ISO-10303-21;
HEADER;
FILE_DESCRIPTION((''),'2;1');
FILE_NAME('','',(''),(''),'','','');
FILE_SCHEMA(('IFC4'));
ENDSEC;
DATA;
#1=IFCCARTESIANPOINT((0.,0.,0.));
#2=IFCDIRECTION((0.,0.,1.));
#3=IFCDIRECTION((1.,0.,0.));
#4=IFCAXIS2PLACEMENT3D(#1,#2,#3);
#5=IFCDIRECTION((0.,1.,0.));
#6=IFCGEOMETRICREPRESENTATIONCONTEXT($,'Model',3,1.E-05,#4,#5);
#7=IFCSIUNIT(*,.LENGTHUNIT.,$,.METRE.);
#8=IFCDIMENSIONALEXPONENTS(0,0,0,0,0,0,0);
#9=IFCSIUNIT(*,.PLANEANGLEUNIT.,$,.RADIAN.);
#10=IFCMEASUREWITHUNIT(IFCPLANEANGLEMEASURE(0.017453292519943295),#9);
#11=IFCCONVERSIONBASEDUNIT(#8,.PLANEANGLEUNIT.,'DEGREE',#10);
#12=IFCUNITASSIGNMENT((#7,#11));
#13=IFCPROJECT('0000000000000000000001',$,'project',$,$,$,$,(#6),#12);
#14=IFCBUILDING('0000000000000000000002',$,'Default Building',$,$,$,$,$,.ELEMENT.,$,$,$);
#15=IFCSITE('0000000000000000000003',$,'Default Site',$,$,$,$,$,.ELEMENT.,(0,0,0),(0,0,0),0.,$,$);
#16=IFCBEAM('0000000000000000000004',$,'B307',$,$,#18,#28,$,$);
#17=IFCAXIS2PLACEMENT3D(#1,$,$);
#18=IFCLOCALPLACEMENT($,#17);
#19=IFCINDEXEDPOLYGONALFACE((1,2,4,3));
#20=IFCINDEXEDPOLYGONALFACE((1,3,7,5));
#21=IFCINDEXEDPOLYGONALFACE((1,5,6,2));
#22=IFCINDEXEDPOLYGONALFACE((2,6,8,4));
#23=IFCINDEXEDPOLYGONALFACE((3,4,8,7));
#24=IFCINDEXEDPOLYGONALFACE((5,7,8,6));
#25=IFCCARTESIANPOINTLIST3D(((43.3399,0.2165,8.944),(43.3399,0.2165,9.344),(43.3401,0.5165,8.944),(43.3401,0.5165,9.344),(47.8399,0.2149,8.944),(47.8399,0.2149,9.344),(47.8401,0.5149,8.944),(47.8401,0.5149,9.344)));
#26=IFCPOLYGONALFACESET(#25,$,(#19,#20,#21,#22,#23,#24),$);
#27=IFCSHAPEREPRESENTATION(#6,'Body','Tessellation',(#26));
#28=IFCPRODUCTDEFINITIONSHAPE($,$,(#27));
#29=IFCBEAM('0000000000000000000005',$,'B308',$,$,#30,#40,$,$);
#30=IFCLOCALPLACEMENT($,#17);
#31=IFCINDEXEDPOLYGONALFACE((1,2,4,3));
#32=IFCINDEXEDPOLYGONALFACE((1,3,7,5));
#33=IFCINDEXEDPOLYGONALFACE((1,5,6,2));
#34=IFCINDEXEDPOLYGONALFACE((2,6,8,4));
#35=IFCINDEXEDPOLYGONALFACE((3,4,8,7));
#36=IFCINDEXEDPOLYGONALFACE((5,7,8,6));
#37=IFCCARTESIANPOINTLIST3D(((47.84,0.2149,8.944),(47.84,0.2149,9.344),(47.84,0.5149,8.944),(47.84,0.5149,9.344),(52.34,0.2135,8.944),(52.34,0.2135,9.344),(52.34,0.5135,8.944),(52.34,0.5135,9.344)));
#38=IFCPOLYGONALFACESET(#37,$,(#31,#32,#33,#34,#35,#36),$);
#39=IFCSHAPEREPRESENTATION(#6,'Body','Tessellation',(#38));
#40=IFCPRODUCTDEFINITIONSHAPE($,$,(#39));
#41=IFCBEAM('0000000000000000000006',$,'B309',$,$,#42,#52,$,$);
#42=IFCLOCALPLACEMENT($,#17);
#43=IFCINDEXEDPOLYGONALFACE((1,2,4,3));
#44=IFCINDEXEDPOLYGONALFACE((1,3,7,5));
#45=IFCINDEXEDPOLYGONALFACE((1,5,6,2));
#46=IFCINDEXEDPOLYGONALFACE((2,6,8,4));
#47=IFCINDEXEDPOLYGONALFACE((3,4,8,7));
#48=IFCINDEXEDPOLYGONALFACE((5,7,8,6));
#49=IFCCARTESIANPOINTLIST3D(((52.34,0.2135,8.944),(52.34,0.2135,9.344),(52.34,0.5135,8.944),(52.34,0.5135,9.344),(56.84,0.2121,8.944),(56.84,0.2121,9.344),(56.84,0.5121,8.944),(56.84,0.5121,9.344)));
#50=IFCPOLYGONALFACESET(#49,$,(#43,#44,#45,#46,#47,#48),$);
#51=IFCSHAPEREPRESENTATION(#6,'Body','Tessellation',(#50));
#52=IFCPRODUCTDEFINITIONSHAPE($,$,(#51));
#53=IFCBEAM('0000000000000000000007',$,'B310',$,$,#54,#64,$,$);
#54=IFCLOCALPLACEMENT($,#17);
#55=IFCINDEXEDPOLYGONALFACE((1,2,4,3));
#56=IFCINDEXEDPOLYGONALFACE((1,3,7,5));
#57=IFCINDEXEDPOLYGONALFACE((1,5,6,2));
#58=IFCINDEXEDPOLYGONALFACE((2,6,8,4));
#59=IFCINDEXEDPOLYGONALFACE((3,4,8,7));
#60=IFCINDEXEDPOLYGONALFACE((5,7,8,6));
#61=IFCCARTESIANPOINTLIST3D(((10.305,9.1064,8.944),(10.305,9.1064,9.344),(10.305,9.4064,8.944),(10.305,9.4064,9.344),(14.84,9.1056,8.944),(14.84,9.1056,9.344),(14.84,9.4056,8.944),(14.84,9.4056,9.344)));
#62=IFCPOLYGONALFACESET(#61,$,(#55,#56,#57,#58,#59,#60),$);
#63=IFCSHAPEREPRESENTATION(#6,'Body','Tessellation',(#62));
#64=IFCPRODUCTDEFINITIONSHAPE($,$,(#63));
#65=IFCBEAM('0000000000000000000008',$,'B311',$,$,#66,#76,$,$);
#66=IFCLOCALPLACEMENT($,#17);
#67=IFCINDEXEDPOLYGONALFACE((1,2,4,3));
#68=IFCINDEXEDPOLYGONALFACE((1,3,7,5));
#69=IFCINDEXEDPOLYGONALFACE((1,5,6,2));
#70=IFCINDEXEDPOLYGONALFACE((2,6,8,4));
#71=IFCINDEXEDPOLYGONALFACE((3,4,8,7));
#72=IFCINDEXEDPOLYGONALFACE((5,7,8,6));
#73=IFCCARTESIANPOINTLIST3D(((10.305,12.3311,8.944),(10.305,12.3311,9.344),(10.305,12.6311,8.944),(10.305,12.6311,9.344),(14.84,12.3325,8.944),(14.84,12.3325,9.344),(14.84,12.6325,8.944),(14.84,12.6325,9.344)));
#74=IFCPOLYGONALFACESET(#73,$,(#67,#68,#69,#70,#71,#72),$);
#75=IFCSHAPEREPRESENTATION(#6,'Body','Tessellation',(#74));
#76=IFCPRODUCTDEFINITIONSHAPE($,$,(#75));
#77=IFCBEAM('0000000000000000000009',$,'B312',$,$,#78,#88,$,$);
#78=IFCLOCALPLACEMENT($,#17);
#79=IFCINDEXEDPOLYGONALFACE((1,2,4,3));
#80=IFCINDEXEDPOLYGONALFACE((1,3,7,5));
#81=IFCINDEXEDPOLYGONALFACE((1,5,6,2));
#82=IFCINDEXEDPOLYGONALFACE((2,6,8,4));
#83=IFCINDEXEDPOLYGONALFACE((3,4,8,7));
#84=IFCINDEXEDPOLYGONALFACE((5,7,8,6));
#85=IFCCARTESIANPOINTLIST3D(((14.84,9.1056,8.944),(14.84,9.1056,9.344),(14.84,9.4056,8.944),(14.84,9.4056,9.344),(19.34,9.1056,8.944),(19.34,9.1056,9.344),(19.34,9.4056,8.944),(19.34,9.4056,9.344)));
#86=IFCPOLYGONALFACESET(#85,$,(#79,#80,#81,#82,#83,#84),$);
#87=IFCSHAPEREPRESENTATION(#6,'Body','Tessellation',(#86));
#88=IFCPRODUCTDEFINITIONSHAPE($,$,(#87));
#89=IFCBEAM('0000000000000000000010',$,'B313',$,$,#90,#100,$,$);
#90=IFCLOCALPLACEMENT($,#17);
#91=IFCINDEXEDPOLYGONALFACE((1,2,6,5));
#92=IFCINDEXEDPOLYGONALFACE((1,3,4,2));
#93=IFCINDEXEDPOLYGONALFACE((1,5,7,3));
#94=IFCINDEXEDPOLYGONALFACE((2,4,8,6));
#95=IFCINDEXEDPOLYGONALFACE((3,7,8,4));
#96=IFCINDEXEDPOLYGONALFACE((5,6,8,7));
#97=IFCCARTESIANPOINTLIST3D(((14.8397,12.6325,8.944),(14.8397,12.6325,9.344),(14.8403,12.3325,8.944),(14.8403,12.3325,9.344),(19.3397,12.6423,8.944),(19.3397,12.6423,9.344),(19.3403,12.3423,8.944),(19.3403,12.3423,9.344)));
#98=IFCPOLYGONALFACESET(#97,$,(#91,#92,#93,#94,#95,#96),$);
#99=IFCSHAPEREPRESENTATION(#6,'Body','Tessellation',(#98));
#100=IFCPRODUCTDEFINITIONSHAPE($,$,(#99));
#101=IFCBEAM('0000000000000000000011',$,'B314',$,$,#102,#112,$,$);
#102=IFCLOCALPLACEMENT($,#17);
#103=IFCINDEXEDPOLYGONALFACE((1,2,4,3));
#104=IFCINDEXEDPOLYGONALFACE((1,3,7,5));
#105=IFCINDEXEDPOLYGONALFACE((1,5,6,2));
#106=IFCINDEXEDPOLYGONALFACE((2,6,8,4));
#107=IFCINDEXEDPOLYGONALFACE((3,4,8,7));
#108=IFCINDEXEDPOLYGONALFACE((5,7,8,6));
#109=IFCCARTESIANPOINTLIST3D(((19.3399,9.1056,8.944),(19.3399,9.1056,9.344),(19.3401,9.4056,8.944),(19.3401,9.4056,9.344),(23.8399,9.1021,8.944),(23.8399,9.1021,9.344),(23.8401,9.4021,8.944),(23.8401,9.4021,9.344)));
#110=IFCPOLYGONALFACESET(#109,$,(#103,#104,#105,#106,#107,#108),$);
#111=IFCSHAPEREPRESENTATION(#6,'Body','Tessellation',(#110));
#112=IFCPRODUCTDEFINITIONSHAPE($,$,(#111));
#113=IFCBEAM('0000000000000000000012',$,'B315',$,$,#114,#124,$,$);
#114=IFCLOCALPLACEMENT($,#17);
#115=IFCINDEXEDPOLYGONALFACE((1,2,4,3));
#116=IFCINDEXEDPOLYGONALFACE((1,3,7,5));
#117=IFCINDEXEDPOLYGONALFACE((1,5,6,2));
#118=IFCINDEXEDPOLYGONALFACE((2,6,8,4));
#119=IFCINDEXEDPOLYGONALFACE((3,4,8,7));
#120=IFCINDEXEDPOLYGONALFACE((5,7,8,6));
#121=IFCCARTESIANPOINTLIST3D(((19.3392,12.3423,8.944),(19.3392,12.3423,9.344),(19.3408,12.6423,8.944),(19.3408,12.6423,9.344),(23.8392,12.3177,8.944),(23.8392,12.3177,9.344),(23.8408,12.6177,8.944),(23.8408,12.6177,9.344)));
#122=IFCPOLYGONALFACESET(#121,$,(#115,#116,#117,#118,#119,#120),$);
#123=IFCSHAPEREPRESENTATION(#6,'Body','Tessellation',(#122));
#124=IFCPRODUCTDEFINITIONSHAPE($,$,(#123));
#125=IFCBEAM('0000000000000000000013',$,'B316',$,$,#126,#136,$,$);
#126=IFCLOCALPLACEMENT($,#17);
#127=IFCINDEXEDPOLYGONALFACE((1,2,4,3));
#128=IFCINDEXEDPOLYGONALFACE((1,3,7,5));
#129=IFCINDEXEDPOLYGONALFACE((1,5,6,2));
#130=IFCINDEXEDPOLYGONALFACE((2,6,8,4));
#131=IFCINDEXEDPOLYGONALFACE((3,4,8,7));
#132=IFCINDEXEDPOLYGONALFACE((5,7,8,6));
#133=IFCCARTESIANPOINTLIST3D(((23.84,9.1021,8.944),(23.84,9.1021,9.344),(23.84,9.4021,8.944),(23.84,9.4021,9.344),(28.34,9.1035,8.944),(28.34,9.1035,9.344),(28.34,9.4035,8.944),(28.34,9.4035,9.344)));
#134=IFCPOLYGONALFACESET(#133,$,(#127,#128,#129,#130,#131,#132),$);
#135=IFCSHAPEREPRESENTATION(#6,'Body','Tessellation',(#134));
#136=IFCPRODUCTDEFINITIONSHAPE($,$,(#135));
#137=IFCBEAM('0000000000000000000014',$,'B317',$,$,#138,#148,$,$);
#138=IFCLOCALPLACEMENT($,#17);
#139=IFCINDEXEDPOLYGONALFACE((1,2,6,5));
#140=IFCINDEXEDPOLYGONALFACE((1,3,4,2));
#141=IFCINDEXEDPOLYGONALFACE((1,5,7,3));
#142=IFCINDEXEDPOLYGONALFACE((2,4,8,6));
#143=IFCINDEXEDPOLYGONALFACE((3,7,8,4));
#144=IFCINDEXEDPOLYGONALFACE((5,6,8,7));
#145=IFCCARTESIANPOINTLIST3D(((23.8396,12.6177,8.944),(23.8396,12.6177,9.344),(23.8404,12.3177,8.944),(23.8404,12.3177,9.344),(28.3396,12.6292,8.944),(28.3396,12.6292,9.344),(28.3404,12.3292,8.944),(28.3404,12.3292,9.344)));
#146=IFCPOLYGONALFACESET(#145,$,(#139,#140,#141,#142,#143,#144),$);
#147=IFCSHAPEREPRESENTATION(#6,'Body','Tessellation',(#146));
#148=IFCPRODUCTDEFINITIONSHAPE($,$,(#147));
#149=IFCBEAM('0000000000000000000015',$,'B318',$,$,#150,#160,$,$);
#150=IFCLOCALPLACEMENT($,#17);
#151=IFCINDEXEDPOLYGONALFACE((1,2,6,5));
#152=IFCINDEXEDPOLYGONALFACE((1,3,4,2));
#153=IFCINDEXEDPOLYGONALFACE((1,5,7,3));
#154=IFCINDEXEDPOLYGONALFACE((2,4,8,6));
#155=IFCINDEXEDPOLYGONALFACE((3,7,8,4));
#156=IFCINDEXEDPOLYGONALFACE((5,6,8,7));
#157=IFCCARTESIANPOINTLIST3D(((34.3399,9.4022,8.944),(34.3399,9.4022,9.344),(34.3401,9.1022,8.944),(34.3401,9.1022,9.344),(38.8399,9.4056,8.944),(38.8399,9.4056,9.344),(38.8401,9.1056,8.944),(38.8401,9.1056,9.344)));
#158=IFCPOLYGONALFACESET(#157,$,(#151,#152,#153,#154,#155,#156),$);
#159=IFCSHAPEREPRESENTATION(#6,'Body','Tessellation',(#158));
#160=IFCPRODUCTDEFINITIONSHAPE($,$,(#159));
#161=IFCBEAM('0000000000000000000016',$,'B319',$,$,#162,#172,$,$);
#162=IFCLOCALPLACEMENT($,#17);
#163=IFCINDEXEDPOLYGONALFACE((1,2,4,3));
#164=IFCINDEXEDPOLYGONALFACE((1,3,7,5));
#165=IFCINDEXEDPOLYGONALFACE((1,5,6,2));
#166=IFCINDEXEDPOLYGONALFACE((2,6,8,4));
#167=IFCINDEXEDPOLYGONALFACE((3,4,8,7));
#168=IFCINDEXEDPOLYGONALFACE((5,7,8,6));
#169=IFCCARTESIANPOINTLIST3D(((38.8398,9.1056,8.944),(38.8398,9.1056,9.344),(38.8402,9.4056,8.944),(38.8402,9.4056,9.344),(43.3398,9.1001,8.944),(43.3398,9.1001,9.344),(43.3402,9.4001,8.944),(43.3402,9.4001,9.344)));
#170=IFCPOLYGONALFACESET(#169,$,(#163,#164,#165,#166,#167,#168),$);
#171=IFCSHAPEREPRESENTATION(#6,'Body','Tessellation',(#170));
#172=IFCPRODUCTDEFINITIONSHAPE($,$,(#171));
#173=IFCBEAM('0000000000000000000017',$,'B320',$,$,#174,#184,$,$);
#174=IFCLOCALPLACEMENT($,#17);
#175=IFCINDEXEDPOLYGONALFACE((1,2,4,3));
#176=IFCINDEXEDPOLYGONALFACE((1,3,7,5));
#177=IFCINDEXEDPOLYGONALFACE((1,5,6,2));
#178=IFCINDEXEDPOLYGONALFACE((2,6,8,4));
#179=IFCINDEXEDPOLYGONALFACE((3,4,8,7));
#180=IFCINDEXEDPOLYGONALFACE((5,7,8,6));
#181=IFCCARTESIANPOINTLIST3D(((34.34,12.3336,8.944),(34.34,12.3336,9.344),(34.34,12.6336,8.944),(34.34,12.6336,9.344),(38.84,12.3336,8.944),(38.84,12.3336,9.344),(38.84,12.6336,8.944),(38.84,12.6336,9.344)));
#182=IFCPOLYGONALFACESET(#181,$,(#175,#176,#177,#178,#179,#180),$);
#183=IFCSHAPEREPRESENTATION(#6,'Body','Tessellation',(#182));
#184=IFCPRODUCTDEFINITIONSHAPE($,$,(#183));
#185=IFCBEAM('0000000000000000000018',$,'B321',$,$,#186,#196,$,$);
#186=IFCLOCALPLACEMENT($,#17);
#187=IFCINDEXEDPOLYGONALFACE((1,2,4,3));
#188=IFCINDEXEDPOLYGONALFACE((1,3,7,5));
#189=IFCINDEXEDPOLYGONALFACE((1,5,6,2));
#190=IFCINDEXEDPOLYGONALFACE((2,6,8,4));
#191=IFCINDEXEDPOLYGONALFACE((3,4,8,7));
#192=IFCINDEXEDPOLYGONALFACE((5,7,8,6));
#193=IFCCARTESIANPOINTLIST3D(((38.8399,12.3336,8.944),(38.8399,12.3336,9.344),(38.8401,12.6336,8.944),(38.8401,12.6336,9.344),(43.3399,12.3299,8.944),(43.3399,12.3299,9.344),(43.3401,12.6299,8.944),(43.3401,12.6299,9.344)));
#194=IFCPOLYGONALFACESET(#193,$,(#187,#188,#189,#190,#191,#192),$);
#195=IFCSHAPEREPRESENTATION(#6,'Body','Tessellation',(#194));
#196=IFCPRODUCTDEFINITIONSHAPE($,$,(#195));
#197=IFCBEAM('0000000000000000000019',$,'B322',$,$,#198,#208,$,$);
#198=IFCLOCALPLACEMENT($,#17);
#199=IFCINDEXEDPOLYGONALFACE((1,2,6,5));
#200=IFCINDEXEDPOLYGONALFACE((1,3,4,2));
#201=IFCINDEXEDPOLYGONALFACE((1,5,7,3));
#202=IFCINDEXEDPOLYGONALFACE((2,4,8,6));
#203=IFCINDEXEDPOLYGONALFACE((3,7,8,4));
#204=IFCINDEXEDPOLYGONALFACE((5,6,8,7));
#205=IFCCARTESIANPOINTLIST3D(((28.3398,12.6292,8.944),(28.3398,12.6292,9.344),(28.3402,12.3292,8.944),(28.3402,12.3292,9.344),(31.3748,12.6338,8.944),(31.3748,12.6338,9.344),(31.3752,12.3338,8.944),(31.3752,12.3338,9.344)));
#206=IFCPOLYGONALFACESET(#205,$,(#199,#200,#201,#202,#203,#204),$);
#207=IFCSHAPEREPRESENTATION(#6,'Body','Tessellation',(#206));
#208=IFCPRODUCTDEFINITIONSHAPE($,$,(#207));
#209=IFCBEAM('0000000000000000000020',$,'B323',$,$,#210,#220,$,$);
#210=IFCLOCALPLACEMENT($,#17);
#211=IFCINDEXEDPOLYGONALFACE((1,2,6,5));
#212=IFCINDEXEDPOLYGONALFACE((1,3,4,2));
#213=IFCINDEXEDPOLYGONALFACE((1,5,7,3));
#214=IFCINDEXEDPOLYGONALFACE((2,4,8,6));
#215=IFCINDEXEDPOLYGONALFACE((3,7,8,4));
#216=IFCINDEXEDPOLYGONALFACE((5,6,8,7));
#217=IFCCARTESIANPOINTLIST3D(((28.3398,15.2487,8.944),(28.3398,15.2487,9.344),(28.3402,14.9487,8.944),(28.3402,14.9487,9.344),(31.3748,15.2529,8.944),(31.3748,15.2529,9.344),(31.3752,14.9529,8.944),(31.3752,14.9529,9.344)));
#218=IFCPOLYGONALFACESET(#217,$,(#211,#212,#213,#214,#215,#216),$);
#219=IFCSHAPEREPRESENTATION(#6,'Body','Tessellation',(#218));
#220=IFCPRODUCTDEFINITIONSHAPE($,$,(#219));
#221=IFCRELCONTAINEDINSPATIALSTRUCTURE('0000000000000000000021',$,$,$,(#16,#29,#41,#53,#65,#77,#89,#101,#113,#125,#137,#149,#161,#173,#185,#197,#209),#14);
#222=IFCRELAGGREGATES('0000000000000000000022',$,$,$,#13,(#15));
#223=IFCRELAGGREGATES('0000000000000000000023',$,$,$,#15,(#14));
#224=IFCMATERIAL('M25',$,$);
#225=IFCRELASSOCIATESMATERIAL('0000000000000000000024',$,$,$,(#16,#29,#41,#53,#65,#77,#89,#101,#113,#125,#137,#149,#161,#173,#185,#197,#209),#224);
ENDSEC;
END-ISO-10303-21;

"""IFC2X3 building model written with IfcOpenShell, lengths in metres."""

from ifc_helpers import new_model, entity, si_unit, converted_unit, direction, frame, frame_2d, origin_with_axes, place, context, project, spatial, rectangle, extrude, material, element, save


model = new_model("IFC2X3")

# Units and contexts
model_context = context("Model", 3, precision=1e-05, world=origin_with_axes(), true_north=direction((0.0, 1.0, 0.0)))
ifc_project = project(units=[si_unit("LENGTHUNIT", "METRE"), converted_unit("PLANEANGLEUNIT", "DEGREE", entity("IfcPlaneAngleMeasure", 0.017453292519943295), si_unit("PLANEANGLEUNIT", "RADIAN"), dimensions=[0, 0, 0, 0, 0, 0, 0])], contexts=[model_context])

# Site, building
site = spatial("IfcSite", under=ifc_project, Name="Default Site", CompositionType="ELEMENT", RefLatitude=(0, 0, 0), RefLongitude=(0, 0, 0), RefElevation=0.0)
building = spatial("IfcBuilding", under=site, Name="Default Building", CompositionType="ELEMENT")

# Beams
ifc_material = material(Name="M25")
placement = place(None, origin_with_axes())
element("IfcBeam", 1, at=placement, inside=building, material=ifc_material, Name="B307", context=model_context, shape_type="SweptSolid", body=[
    extrude(rectangle(XDim=0.3, YDim=0.4, at=frame_2d((0.0, 0.0), x_axis=(0.0, 1.0, 0.0))), frame((43.34, 0.3665, 9.144), z_axis=(1.0, -0.000358, 0.0), x_axis=(0.0, 0.0, -1.0)), (0.0, 0.0, 1.0), 4.5),
])
element("IfcBeam", 2, at=placement, inside=building, material=ifc_material, Name="B308", context=model_context, shape_type="SweptSolid", body=[
    extrude(rectangle(XDim=0.3, YDim=0.4, at=frame_2d((0.0, 0.0), x_axis=(0.0, 1.0, 0.0))), frame((47.84, 0.3649, 9.144), z_axis=(1.0, -0.000297, 0.0), x_axis=(0.0, 0.0, -1.0)), (0.0, 0.0, 1.0), 4.5),
])
element("IfcBeam", 3, at=placement, inside=building, material=ifc_material, Name="B309", context=model_context, shape_type="SweptSolid", body=[
    extrude(rectangle(XDim=0.3, YDim=0.4, at=frame_2d((0.0, 0.0), x_axis=(0.0, 1.0, 0.0))), frame((52.34, 0.3635, 9.144), z_axis=(1.0, -0.000311, 0.0), x_axis=(0.0, 0.0, -1.0)), (0.0, 0.0, 1.0), 4.5),
])
element("IfcBeam", 4, at=placement, inside=building, material=ifc_material, Name="B310", context=model_context, shape_type="SweptSolid", body=[
    extrude(rectangle(XDim=0.3, YDim=0.4, at=frame_2d((0.0, 0.0), x_axis=(0.0, 1.0, 0.0))), frame((10.305, 9.2564, 9.144), z_axis=(1.0, -0.000182, 0.0), x_axis=(0.0, 0.0, -1.0)), (0.0, 0.0, 1.0), 4.535),
])
element("IfcBeam", 5, at=placement, inside=building, material=ifc_material, Name="B311", context=model_context, shape_type="SweptSolid", body=[
    extrude(rectangle(XDim=0.3, YDim=0.4, at=frame_2d((0.0, 0.0), x_axis=(0.0, 1.0, 0.0))), frame((10.305, 12.4811, 9.144), z_axis=(1.0, 0.000301, 0.0), x_axis=(0.0, 0.0, -1.0)), (0.0, 0.0, 1.0), 4.535),
])
element("IfcBeam", 6, at=placement, inside=building, material=ifc_material, Name="B312", context=model_context, shape_type="SweptSolid", body=[
    extrude(rectangle(XDim=0.3, YDim=0.4, at=frame_2d((0.0, 0.0), x_axis=(0.0, 1.0, 0.0))), frame((14.84, 9.2556, 9.144), z_axis=(1.0, 0.000013, 0.0), x_axis=(0.0, 0.0, -1.0)), (0.0, 0.0, 1.0), 4.5),
])
element("IfcBeam", 7, at=placement, inside=building, material=ifc_material, Name="B313", context=model_context, shape_type="SweptSolid", body=[
    extrude(rectangle(XDim=0.3, YDim=0.4, at=frame_2d((0.0, 0.0), x_axis=(0.0, 1.0, 0.0))), frame((14.84, 12.4825, 9.144), z_axis=(0.999998, 0.002176, 0.0), x_axis=(0.0, 0.0, -1.0)), (0.0, 0.0, 1.0), 4.5),
])
element("IfcBeam", 8, at=placement, inside=building, material=ifc_material, Name="B314", context=model_context, shape_type="SweptSolid", body=[
    extrude(rectangle(XDim=0.3, YDim=0.4, at=frame_2d((0.0, 0.0), x_axis=(0.0, 1.0, 0.0))), frame((19.34, 9.2556, 9.144), z_axis=(1.0, -0.000779, 0.0), x_axis=(0.0, 0.0, -1.0)), (0.0, 0.0, 1.0), 4.5),
])
element("IfcBeam", 9, at=placement, inside=building, material=ifc_material, Name="B315", context=model_context, shape_type="SweptSolid", body=[
    extrude(rectangle(XDim=0.3, YDim=0.4, at=frame_2d((0.0, 0.0), x_axis=(0.0, 1.0, 0.0))), frame((19.34, 12.4923, 9.144), z_axis=(0.999985, -0.005463, 0.0), x_axis=(0.0, 0.0, -1.0)), (0.0, 0.0, 1.0), 4.5001),
])
element("IfcBeam", 10, at=placement, inside=building, material=ifc_material, Name="B316", context=model_context, shape_type="SweptSolid", body=[
    extrude(rectangle(XDim=0.3, YDim=0.4, at=frame_2d((0.0, 0.0), x_axis=(0.0, 1.0, 0.0))), frame((23.84, 9.2521, 9.144), z_axis=(1.0, 0.000307, 0.0), x_axis=(0.0, 0.0, -1.0)), (0.0, 0.0, 1.0), 4.5),
])
element("IfcBeam", 11, at=placement, inside=building, material=ifc_material, Name="B317", context=model_context, shape_type="SweptSolid", body=[
    extrude(rectangle(XDim=0.3, YDim=0.4, at=frame_2d((0.0, 0.0), x_axis=(0.0, 1.0, 0.0))), frame((23.84, 12.4677, 9.144), z_axis=(0.999997, 0.002551, 0.0), x_axis=(0.0, 0.0, -1.0)), (0.0, 0.0, 1.0), 4.5),
])
element("IfcBeam", 12, at=placement, inside=building, material=ifc_material, Name="B318", context=model_context, shape_type="SweptSolid", body=[
    extrude(rectangle(XDim=0.3, YDim=0.4, at=frame_2d((0.0, 0.0), x_axis=(0.0, 1.0, 0.0))), frame((34.34, 9.2522, 9.144), z_axis=(1.0, 0.000748, 0.0), x_axis=(0.0, 0.0, -1.0)), (0.0, 0.0, 1.0), 4.5),
])
element("IfcBeam", 13, at=placement, inside=building, material=ifc_material, Name="B319", context=model_context, shape_type="SweptSolid", body=[
    extrude(rectangle(XDim=0.3, YDim=0.4, at=frame_2d((0.0, 0.0), x_axis=(0.0, 1.0, 0.0))), frame((38.84, 9.2556, 9.144), z_axis=(0.999999, -0.001227, 0.0), x_axis=(0.0, 0.0, -1.0)), (0.0, 0.0, 1.0), 4.5),
])
element("IfcBeam", 14, at=placement, inside=building, material=ifc_material, Name="B320", context=model_context, shape_type="SweptSolid", body=[
    extrude(rectangle(XDim=0.3, YDim=0.4, at=frame_2d((0.0, 0.0), x_axis=(0.0, 1.0, 0.0))), frame((34.34, 12.4836, 9.144), z_axis=(1.0, -0.000008, 0.0), x_axis=(0.0, 0.0, -1.0)), (0.0, 0.0, 1.0), 4.5),
])
element("IfcBeam", 15, at=placement, inside=building, material=ifc_material, Name="B321", context=model_context, shape_type="SweptSolid", body=[
    extrude(rectangle(XDim=0.3, YDim=0.4, at=frame_2d((0.0, 0.0), x_axis=(0.0, 1.0, 0.0))), frame((38.84, 12.4836, 9.144), z_axis=(1.0, -0.000826, 0.0), x_axis=(0.0, 0.0, -1.0)), (0.0, 0.0, 1.0), 4.5),
])
element("IfcBeam", 16, at=placement, inside=building, material=ifc_material, Name="B322", context=model_context, shape_type="SweptSolid", body=[
    extrude(rectangle(XDim=0.3, YDim=0.4, at=frame_2d((0.0, 0.0), x_axis=(0.0, 1.0, 0.0))), frame((28.34, 12.4792, 9.144), z_axis=(0.999999, 0.001542, 0.0), x_axis=(0.0, 0.0, -1.0)), (0.0, 0.0, 1.0), 3.035),
])
element("IfcBeam", 17, at=placement, inside=building, material=ifc_material, Name="B323", context=model_context, shape_type="SweptSolid", body=[
    extrude(rectangle(XDim=0.3, YDim=0.4, at=frame_2d((0.0, 0.0), x_axis=(0.0, 1.0, 0.0))), frame((31.375, 15.1029, 9.144), z_axis=(-0.999999, -0.001391, 0.0), x_axis=(0.0, 0.0, -1.0)), (0.0, 0.0, 1.0), 3.035),
])

save(model, "model.ifc")
